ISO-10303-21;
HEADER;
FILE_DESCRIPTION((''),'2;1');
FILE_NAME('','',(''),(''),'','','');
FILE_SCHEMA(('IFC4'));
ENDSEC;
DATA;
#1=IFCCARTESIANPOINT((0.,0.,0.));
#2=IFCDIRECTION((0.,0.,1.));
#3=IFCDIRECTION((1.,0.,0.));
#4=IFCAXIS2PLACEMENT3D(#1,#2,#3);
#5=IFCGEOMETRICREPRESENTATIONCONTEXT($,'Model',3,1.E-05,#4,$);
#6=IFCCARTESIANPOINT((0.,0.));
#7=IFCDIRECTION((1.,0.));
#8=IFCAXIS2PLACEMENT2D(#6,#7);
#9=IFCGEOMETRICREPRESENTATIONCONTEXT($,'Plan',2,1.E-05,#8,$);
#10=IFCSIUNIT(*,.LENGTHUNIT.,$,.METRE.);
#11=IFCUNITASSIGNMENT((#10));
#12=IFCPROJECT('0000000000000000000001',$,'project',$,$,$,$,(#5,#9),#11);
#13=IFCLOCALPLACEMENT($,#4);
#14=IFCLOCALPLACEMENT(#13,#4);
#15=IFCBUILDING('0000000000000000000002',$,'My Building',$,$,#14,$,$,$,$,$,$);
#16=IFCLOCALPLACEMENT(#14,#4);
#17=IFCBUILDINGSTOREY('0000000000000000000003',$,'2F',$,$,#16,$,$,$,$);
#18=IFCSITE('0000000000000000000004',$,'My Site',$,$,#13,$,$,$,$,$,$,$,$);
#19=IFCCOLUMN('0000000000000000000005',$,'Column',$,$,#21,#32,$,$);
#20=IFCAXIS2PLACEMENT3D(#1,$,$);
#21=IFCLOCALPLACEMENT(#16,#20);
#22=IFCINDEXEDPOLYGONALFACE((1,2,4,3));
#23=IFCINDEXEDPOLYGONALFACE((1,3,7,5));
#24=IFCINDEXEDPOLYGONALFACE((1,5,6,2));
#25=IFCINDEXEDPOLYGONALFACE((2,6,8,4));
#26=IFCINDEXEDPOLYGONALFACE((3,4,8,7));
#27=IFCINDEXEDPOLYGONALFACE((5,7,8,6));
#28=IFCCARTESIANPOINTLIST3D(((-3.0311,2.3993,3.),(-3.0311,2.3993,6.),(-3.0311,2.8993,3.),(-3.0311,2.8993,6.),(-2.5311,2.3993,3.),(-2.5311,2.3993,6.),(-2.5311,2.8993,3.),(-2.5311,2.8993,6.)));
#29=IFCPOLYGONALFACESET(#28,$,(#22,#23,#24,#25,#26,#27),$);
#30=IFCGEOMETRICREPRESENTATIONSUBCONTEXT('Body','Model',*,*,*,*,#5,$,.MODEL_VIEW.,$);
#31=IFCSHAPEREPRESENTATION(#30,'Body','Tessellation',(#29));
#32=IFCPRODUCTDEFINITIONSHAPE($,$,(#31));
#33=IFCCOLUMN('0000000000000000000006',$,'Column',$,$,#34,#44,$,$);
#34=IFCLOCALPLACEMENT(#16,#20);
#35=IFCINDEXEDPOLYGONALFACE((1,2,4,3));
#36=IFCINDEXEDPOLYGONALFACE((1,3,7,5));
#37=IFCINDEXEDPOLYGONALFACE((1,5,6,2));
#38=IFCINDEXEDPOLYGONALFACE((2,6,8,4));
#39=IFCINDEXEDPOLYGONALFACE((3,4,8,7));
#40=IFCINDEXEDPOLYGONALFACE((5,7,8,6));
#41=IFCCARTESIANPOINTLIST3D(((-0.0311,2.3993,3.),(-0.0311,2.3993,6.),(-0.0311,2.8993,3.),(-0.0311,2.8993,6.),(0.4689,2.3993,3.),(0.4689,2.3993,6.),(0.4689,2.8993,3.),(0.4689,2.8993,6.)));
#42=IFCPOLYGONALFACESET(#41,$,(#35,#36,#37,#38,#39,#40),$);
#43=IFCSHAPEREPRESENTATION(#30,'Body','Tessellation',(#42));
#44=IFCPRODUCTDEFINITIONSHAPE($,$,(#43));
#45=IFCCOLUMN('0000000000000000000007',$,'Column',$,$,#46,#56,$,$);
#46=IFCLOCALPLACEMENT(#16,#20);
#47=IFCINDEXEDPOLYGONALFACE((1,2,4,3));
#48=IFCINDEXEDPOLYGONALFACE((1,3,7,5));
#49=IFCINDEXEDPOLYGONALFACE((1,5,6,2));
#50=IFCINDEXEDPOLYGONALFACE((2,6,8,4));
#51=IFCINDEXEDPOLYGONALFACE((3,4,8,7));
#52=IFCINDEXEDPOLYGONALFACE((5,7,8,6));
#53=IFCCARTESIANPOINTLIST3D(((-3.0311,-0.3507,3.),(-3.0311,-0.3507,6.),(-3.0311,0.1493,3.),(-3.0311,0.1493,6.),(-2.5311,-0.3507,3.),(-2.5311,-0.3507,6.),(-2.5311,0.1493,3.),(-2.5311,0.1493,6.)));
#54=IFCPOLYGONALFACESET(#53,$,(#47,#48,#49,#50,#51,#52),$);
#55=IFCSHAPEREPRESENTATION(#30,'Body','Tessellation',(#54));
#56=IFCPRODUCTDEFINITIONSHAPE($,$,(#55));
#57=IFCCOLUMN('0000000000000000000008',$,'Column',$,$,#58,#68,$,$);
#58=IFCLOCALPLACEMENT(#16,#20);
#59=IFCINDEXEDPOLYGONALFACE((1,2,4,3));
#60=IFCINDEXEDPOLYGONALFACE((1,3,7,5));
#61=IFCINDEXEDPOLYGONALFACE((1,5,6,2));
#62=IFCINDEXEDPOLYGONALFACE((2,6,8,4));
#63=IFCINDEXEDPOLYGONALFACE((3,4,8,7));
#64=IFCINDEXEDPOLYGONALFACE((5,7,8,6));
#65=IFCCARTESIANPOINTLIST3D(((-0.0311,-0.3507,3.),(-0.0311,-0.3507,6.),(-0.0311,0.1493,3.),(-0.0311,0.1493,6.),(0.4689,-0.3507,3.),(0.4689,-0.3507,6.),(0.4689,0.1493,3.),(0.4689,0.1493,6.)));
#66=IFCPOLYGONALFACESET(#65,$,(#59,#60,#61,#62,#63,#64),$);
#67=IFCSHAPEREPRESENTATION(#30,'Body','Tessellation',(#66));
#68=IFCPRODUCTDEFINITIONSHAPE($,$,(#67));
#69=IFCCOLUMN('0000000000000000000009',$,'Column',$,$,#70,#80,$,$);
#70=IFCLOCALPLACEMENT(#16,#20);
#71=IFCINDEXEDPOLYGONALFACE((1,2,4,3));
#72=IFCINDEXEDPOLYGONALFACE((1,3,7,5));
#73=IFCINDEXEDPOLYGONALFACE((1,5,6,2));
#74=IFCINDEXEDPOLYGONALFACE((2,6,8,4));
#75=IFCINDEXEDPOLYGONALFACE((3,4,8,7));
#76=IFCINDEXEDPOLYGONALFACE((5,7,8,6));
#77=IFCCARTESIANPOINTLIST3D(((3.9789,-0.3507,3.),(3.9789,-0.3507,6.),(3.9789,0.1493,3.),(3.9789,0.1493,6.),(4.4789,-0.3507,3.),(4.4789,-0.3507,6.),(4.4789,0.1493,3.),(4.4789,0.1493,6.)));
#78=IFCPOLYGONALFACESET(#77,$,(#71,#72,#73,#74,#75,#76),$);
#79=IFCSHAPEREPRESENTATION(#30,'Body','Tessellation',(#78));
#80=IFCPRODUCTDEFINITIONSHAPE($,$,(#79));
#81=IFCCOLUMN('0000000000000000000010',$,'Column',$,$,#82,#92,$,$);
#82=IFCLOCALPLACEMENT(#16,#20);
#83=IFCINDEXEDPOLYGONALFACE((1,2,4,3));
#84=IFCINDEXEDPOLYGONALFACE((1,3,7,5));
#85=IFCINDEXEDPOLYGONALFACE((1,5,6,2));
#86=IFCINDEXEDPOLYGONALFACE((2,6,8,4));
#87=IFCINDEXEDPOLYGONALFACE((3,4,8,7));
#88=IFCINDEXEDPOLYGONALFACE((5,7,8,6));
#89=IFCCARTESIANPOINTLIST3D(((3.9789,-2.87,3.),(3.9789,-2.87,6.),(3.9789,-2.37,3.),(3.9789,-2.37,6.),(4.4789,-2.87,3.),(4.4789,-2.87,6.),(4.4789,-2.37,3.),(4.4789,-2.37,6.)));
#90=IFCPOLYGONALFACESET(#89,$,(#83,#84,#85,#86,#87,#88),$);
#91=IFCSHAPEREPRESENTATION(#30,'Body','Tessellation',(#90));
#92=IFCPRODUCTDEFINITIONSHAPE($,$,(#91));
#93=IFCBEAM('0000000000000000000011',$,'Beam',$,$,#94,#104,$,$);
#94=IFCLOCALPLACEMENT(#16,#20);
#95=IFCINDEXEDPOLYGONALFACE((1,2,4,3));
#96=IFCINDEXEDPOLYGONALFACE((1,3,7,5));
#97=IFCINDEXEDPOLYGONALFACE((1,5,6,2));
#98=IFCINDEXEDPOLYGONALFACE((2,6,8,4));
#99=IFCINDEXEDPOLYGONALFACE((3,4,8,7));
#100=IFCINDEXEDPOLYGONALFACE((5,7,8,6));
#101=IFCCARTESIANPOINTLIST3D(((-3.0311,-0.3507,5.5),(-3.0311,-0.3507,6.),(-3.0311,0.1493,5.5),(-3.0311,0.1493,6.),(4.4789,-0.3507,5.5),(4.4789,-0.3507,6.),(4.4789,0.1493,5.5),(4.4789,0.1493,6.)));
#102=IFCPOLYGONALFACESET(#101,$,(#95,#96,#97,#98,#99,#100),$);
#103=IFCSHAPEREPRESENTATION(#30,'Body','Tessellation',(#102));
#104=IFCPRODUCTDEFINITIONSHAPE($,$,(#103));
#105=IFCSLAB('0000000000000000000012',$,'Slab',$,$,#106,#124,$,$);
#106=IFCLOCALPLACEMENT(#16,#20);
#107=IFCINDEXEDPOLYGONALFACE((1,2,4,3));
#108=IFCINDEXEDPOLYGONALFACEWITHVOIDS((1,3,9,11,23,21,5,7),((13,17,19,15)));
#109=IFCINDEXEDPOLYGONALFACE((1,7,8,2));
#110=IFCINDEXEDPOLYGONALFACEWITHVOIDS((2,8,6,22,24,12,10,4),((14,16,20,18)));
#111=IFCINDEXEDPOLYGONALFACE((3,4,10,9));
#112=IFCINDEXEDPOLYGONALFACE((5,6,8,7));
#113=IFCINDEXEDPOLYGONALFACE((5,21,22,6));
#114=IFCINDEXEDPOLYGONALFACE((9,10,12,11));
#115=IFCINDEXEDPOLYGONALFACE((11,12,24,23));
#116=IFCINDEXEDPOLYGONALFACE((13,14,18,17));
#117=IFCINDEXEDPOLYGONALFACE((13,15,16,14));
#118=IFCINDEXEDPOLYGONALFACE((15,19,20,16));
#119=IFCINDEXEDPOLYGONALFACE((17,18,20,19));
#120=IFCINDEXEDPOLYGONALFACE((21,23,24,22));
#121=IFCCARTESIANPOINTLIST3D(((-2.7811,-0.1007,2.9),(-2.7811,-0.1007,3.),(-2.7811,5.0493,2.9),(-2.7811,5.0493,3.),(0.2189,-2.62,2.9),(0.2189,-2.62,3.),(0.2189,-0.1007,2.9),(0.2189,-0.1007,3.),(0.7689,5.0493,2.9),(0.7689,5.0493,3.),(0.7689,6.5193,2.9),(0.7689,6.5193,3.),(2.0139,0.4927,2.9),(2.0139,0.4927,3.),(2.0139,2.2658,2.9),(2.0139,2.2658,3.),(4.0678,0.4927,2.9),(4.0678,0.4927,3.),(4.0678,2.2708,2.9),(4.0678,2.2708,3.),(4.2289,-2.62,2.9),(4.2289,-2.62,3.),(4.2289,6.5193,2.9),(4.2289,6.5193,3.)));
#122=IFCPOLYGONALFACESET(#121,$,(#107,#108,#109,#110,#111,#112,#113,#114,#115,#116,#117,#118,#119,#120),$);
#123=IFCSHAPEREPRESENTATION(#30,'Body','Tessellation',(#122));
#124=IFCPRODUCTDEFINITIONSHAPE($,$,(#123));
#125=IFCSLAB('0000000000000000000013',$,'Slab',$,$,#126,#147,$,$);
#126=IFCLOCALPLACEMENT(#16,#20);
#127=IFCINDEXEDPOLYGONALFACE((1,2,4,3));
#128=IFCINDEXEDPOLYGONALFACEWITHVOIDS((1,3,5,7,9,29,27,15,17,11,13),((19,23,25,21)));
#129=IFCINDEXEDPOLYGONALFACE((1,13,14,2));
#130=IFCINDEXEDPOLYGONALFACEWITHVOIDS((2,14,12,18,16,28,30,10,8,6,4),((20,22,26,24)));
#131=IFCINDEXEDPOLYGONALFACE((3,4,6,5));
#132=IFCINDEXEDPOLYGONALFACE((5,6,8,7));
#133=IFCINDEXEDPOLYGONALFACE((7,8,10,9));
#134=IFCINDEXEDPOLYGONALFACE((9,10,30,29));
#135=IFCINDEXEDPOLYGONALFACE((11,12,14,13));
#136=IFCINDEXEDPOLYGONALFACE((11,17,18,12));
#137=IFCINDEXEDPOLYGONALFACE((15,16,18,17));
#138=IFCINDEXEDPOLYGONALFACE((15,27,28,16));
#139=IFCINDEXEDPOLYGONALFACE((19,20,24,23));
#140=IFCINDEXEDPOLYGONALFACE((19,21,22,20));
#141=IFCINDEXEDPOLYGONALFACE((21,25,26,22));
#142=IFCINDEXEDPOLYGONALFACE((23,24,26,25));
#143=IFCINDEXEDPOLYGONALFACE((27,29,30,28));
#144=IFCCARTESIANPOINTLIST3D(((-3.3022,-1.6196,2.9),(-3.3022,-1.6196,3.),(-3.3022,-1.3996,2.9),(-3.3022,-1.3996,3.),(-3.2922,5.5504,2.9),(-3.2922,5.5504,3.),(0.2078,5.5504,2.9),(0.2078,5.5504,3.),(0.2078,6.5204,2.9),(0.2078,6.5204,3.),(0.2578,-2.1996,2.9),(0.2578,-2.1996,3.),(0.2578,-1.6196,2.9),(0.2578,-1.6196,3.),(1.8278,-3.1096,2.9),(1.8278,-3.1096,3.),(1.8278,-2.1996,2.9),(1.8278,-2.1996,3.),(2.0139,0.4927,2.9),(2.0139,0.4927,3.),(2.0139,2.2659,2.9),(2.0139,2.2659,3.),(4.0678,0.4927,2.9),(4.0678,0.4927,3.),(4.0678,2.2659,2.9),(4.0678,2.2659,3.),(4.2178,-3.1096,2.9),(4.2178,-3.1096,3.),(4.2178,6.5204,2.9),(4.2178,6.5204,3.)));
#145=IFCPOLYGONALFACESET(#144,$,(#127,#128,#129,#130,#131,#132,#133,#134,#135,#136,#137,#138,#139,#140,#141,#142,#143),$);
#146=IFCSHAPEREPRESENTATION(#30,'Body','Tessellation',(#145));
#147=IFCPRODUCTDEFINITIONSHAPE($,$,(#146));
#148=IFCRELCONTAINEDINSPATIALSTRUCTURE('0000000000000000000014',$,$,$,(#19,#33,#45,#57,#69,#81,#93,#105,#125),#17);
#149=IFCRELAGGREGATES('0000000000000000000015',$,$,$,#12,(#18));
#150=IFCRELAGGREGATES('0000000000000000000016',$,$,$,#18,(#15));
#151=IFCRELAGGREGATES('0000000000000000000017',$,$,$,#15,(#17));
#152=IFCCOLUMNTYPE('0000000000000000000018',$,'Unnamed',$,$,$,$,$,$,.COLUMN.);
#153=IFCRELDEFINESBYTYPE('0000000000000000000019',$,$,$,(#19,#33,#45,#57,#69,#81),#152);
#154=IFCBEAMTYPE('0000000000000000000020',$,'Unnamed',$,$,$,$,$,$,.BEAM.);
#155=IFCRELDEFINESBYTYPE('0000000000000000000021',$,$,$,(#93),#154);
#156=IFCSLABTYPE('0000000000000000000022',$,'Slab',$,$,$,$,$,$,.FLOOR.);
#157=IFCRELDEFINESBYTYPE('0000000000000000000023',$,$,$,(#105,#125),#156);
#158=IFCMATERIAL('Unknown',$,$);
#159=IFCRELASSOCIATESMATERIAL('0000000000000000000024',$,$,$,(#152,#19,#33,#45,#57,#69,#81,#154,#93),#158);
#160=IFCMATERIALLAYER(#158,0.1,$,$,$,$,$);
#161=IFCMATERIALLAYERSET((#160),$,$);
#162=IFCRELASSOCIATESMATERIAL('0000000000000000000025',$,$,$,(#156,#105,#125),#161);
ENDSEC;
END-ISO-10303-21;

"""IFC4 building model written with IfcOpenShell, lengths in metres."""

from ifc_helpers import new_model, si_unit, frame, origin_with_axes, origin_2d_with_axis, place, context, subcontext, project, spatial, indexed_curve, rectangle, outline, extrude, material, layer, layer_set, layer_usage, material_profile, profile_set, profile_usage, type_object, element, save


model = new_model("IFC4")

# Units and contexts
model_context = context("Model", 3, precision=1e-05, world=origin_with_axes())
plan_context = context("Plan", 2, precision=1e-05, world=origin_2d_with_axis())
body_context_1 = subcontext(model_context, "Body", "Model", "MODEL_VIEW")
ifc_project = project(units=[si_unit("LENGTHUNIT", "METRE")], contexts=[model_context, plan_context])

# Site, building, storey
site_placement = place(None, origin_with_axes())
site = spatial("IfcSite", under=ifc_project, at=site_placement, Name="My Site")
building_placement = place(site_placement, origin_with_axes())
building = spatial("IfcBuilding", under=site, at=building_placement, Name="My Building")
storey_placement = place(building_placement, origin_with_axes())
storey = spatial("IfcBuildingStorey", under=building, at=storey_placement, Name="2F")

# Columns
ifc_material = material(Name="Unknown")
ifc_material_profile_1 = material_profile(ifc_material, rectangle(XDim=0.5, YDim=0.5))
ifc_profile_set_1 = profile_set([ifc_material_profile_1])
ifc_profile_usage_1 = profile_usage(ifc_profile_set_1, cardinal=7)
column_type = type_object("IfcColumnType", Name="Unnamed", PredefinedType="COLUMN", material=ifc_profile_set_1)
column_1_placement = place(storey_placement, frame((-2.5311, 2.8993, 3.0), z_axis=(0.0, 0.0, 1.0), x_axis=(1.0, 0.0, 0.0)))
element("IfcColumn", 1, at=column_1_placement, inside=storey, type_object=column_type, material=ifc_profile_usage_1, Name="Column", context=body_context_1, shape_type="SweptSolid", body=[
    extrude(rectangle(XDim=0.5, YDim=0.5), frame((-0.25, -0.25, 0.0), z_axis=(0.0, 0.0, 1.0), x_axis=(1.0, 0.0, 0.0)), (0.0, 0.0, 1.0), 3.0),
])
ifc_profile_usage_2 = profile_usage(ifc_profile_set_1, cardinal=7)
column_2_placement = place(storey_placement, frame((0.4689, 2.8993, 3.0), z_axis=(0.0, 0.0, 1.0), x_axis=(1.0, 0.0, 0.0)))
element("IfcColumn", 2, at=column_2_placement, inside=storey, type_object=column_type, material=ifc_profile_usage_2, Name="Column", context=body_context_1, shape_type="SweptSolid", body=[
    extrude(rectangle(XDim=0.5, YDim=0.5), frame((-0.25, -0.25, 0.0), z_axis=(0.0, 0.0, 1.0), x_axis=(1.0, 0.0, 0.0)), (0.0, 0.0, 1.0), 3.0),
])
ifc_profile_usage_3 = profile_usage(ifc_profile_set_1, cardinal=7)
column_3_placement = place(storey_placement, frame((-2.5311, 0.1493, 3.0), z_axis=(0.0, 0.0, 1.0), x_axis=(1.0, 0.0, 0.0)))
element("IfcColumn", 3, at=column_3_placement, inside=storey, type_object=column_type, material=ifc_profile_usage_3, Name="Column", context=body_context_1, shape_type="SweptSolid", body=[
    extrude(rectangle(XDim=0.5, YDim=0.5), frame((-0.25, -0.25, 0.0), z_axis=(0.0, 0.0, 1.0), x_axis=(1.0, 0.0, 0.0)), (0.0, 0.0, 1.0), 3.0),
])
ifc_profile_usage_4 = profile_usage(ifc_profile_set_1, cardinal=7)
column_4_placement = place(storey_placement, frame((0.4689, 0.1493, 3.0), z_axis=(0.0, 0.0, 1.0), x_axis=(1.0, 0.0, 0.0)))
element("IfcColumn", 4, at=column_4_placement, inside=storey, type_object=column_type, material=ifc_profile_usage_4, Name="Column", context=body_context_1, shape_type="SweptSolid", body=[
    extrude(rectangle(XDim=0.5, YDim=0.5), frame((-0.25, -0.25, 0.0), z_axis=(0.0, 0.0, 1.0), x_axis=(1.0, 0.0, 0.0)), (0.0, 0.0, 1.0), 3.0),
])
ifc_profile_usage_5 = profile_usage(ifc_profile_set_1, cardinal=7)
column_5_placement = place(storey_placement, frame((4.4789, 0.1493, 3.0), z_axis=(0.0, 0.0, 1.0), x_axis=(1.0, 0.0, 0.0)))
element("IfcColumn", 5, at=column_5_placement, inside=storey, type_object=column_type, material=ifc_profile_usage_5, Name="Column", context=body_context_1, shape_type="SweptSolid", body=[
    extrude(rectangle(XDim=0.5, YDim=0.5), frame((-0.25, -0.25, 0.0), z_axis=(0.0, 0.0, 1.0), x_axis=(1.0, 0.0, 0.0)), (0.0, 0.0, 1.0), 3.0),
])
ifc_profile_usage_6 = profile_usage(ifc_profile_set_1, cardinal=7)
column_6_placement = place(storey_placement, frame((4.4789, -2.37, 3.0), z_axis=(0.0, 0.0, 1.0), x_axis=(1.0, 0.0, 0.0)))
element("IfcColumn", 6, at=column_6_placement, inside=storey, type_object=column_type, material=ifc_profile_usage_6, Name="Column", context=body_context_1, shape_type="SweptSolid", body=[
    extrude(rectangle(XDim=0.5, YDim=0.5), frame((-0.25, -0.25, 0.0), z_axis=(0.0, 0.0, 1.0), x_axis=(1.0, 0.0, 0.0)), (0.0, 0.0, 1.0), 3.0),
])

# Beam
ifc_material_profile_2 = material_profile(ifc_material, rectangle(XDim=0.5, YDim=0.5))
ifc_profile_set_2 = profile_set([ifc_material_profile_2])
ifc_profile_usage_7 = profile_usage(ifc_profile_set_2, cardinal=7)
beam_type = type_object("IfcBeamType", Name="Unnamed", PredefinedType="BEAM", material=ifc_profile_set_2)
beam_placement = place(storey_placement, frame((-3.0311, 0.1493, 6.0), z_axis=(1.0, -0.000001, 0.000001), x_axis=(0.000001, 1.0, 0.0)))
element("IfcBeam", 7, at=beam_placement, inside=storey, type_object=beam_type, material=ifc_profile_usage_7, Name="Beam", context=body_context_1, shape_type="SweptSolid", body=[
    extrude(rectangle(XDim=0.5, YDim=0.5), frame((-0.25, -0.25, 0.0), z_axis=(0.0, 0.0, 1.0), x_axis=(1.0, 0.0, 0.0)), (0.0, 0.0, 1.0), 7.51),
])

# Slabs
ifc_layer_1 = layer(ifc_material, 0.1)
ifc_layer_set_1 = layer_set([ifc_layer_1])
ifc_layer_usage_1 = layer_usage(ifc_layer_set_1, "AXIS3", "POSITIVE", -0.1)
slab_type = type_object("IfcSlabType", Name="Slab", PredefinedType="FLOOR", material=ifc_layer_set_1)
slab_1_placement = place(storey_placement, frame((0.2189, -2.62, 3.0), z_axis=(0.0, 0.0, 1.0), x_axis=(1.0, 0.0, 0.0)))
element("IfcSlab", 8, at=slab_1_placement, inside=storey, type_object=slab_type, material=ifc_layer_usage_1, Name="Slab", context=body_context_1, shape_type="SweptSolid", body=[
    extrude(outline(indexed_curve([(0.0, 0.0), (4.01, 0.0), (4.01, 9.1393), (0.55, 9.1393), (0.55, 7.6693), (-3.0, 7.6693), (-3.0, 2.5193), (0.0, 2.5193), (0.0, 0.0)]), holes=[indexed_curve([(1.7949, 4.8858), (3.8489, 4.8908), (3.8489, 3.1127), (1.7949, 3.1127), (1.7949, 4.8858)])]), frame((0.0, 0.0, -0.1), z_axis=(0.0, 0.0, 1.0), x_axis=(1.0, 0.0, 0.0)), (0.0, 0.0, 1.0), 0.1),
])
ifc_layer_usage_2 = layer_usage(ifc_layer_set_1, "AXIS3", "POSITIVE", -0.1)
slab_2_placement = place(storey_placement, frame((-3.3022, -1.3996, 3.0), z_axis=(0.0, 0.0, 1.0), x_axis=(1.0, 0.0, 0.0)))
element("IfcSlab", 9, at=slab_2_placement, inside=storey, type_object=slab_type, material=ifc_layer_usage_2, Name="Slab", context=body_context_1, shape_type="SweptSolid", body=[
    extrude(outline(indexed_curve([(0.01, 6.95), (3.51, 6.95), (3.51, 7.92), (7.52, 7.92), (7.52, -1.71), (5.13, -1.71), (5.13, -0.8), (3.56, -0.8), (3.56, -0.22), (0.0, -0.22), (0.0, 0.0), (0.01, 6.95)]), holes=[indexed_curve([(5.3161, 1.8923), (7.37, 1.8923), (7.37, 3.6655), (5.3161, 3.6655), (5.3161, 1.8923)])]), frame((0.0, 0.0, -0.1), z_axis=(0.0, 0.0, 1.0), x_axis=(1.0, 0.0, 0.0)), (0.0, 0.0, 1.0), 0.1),
])

save(model, "model.ifc")
